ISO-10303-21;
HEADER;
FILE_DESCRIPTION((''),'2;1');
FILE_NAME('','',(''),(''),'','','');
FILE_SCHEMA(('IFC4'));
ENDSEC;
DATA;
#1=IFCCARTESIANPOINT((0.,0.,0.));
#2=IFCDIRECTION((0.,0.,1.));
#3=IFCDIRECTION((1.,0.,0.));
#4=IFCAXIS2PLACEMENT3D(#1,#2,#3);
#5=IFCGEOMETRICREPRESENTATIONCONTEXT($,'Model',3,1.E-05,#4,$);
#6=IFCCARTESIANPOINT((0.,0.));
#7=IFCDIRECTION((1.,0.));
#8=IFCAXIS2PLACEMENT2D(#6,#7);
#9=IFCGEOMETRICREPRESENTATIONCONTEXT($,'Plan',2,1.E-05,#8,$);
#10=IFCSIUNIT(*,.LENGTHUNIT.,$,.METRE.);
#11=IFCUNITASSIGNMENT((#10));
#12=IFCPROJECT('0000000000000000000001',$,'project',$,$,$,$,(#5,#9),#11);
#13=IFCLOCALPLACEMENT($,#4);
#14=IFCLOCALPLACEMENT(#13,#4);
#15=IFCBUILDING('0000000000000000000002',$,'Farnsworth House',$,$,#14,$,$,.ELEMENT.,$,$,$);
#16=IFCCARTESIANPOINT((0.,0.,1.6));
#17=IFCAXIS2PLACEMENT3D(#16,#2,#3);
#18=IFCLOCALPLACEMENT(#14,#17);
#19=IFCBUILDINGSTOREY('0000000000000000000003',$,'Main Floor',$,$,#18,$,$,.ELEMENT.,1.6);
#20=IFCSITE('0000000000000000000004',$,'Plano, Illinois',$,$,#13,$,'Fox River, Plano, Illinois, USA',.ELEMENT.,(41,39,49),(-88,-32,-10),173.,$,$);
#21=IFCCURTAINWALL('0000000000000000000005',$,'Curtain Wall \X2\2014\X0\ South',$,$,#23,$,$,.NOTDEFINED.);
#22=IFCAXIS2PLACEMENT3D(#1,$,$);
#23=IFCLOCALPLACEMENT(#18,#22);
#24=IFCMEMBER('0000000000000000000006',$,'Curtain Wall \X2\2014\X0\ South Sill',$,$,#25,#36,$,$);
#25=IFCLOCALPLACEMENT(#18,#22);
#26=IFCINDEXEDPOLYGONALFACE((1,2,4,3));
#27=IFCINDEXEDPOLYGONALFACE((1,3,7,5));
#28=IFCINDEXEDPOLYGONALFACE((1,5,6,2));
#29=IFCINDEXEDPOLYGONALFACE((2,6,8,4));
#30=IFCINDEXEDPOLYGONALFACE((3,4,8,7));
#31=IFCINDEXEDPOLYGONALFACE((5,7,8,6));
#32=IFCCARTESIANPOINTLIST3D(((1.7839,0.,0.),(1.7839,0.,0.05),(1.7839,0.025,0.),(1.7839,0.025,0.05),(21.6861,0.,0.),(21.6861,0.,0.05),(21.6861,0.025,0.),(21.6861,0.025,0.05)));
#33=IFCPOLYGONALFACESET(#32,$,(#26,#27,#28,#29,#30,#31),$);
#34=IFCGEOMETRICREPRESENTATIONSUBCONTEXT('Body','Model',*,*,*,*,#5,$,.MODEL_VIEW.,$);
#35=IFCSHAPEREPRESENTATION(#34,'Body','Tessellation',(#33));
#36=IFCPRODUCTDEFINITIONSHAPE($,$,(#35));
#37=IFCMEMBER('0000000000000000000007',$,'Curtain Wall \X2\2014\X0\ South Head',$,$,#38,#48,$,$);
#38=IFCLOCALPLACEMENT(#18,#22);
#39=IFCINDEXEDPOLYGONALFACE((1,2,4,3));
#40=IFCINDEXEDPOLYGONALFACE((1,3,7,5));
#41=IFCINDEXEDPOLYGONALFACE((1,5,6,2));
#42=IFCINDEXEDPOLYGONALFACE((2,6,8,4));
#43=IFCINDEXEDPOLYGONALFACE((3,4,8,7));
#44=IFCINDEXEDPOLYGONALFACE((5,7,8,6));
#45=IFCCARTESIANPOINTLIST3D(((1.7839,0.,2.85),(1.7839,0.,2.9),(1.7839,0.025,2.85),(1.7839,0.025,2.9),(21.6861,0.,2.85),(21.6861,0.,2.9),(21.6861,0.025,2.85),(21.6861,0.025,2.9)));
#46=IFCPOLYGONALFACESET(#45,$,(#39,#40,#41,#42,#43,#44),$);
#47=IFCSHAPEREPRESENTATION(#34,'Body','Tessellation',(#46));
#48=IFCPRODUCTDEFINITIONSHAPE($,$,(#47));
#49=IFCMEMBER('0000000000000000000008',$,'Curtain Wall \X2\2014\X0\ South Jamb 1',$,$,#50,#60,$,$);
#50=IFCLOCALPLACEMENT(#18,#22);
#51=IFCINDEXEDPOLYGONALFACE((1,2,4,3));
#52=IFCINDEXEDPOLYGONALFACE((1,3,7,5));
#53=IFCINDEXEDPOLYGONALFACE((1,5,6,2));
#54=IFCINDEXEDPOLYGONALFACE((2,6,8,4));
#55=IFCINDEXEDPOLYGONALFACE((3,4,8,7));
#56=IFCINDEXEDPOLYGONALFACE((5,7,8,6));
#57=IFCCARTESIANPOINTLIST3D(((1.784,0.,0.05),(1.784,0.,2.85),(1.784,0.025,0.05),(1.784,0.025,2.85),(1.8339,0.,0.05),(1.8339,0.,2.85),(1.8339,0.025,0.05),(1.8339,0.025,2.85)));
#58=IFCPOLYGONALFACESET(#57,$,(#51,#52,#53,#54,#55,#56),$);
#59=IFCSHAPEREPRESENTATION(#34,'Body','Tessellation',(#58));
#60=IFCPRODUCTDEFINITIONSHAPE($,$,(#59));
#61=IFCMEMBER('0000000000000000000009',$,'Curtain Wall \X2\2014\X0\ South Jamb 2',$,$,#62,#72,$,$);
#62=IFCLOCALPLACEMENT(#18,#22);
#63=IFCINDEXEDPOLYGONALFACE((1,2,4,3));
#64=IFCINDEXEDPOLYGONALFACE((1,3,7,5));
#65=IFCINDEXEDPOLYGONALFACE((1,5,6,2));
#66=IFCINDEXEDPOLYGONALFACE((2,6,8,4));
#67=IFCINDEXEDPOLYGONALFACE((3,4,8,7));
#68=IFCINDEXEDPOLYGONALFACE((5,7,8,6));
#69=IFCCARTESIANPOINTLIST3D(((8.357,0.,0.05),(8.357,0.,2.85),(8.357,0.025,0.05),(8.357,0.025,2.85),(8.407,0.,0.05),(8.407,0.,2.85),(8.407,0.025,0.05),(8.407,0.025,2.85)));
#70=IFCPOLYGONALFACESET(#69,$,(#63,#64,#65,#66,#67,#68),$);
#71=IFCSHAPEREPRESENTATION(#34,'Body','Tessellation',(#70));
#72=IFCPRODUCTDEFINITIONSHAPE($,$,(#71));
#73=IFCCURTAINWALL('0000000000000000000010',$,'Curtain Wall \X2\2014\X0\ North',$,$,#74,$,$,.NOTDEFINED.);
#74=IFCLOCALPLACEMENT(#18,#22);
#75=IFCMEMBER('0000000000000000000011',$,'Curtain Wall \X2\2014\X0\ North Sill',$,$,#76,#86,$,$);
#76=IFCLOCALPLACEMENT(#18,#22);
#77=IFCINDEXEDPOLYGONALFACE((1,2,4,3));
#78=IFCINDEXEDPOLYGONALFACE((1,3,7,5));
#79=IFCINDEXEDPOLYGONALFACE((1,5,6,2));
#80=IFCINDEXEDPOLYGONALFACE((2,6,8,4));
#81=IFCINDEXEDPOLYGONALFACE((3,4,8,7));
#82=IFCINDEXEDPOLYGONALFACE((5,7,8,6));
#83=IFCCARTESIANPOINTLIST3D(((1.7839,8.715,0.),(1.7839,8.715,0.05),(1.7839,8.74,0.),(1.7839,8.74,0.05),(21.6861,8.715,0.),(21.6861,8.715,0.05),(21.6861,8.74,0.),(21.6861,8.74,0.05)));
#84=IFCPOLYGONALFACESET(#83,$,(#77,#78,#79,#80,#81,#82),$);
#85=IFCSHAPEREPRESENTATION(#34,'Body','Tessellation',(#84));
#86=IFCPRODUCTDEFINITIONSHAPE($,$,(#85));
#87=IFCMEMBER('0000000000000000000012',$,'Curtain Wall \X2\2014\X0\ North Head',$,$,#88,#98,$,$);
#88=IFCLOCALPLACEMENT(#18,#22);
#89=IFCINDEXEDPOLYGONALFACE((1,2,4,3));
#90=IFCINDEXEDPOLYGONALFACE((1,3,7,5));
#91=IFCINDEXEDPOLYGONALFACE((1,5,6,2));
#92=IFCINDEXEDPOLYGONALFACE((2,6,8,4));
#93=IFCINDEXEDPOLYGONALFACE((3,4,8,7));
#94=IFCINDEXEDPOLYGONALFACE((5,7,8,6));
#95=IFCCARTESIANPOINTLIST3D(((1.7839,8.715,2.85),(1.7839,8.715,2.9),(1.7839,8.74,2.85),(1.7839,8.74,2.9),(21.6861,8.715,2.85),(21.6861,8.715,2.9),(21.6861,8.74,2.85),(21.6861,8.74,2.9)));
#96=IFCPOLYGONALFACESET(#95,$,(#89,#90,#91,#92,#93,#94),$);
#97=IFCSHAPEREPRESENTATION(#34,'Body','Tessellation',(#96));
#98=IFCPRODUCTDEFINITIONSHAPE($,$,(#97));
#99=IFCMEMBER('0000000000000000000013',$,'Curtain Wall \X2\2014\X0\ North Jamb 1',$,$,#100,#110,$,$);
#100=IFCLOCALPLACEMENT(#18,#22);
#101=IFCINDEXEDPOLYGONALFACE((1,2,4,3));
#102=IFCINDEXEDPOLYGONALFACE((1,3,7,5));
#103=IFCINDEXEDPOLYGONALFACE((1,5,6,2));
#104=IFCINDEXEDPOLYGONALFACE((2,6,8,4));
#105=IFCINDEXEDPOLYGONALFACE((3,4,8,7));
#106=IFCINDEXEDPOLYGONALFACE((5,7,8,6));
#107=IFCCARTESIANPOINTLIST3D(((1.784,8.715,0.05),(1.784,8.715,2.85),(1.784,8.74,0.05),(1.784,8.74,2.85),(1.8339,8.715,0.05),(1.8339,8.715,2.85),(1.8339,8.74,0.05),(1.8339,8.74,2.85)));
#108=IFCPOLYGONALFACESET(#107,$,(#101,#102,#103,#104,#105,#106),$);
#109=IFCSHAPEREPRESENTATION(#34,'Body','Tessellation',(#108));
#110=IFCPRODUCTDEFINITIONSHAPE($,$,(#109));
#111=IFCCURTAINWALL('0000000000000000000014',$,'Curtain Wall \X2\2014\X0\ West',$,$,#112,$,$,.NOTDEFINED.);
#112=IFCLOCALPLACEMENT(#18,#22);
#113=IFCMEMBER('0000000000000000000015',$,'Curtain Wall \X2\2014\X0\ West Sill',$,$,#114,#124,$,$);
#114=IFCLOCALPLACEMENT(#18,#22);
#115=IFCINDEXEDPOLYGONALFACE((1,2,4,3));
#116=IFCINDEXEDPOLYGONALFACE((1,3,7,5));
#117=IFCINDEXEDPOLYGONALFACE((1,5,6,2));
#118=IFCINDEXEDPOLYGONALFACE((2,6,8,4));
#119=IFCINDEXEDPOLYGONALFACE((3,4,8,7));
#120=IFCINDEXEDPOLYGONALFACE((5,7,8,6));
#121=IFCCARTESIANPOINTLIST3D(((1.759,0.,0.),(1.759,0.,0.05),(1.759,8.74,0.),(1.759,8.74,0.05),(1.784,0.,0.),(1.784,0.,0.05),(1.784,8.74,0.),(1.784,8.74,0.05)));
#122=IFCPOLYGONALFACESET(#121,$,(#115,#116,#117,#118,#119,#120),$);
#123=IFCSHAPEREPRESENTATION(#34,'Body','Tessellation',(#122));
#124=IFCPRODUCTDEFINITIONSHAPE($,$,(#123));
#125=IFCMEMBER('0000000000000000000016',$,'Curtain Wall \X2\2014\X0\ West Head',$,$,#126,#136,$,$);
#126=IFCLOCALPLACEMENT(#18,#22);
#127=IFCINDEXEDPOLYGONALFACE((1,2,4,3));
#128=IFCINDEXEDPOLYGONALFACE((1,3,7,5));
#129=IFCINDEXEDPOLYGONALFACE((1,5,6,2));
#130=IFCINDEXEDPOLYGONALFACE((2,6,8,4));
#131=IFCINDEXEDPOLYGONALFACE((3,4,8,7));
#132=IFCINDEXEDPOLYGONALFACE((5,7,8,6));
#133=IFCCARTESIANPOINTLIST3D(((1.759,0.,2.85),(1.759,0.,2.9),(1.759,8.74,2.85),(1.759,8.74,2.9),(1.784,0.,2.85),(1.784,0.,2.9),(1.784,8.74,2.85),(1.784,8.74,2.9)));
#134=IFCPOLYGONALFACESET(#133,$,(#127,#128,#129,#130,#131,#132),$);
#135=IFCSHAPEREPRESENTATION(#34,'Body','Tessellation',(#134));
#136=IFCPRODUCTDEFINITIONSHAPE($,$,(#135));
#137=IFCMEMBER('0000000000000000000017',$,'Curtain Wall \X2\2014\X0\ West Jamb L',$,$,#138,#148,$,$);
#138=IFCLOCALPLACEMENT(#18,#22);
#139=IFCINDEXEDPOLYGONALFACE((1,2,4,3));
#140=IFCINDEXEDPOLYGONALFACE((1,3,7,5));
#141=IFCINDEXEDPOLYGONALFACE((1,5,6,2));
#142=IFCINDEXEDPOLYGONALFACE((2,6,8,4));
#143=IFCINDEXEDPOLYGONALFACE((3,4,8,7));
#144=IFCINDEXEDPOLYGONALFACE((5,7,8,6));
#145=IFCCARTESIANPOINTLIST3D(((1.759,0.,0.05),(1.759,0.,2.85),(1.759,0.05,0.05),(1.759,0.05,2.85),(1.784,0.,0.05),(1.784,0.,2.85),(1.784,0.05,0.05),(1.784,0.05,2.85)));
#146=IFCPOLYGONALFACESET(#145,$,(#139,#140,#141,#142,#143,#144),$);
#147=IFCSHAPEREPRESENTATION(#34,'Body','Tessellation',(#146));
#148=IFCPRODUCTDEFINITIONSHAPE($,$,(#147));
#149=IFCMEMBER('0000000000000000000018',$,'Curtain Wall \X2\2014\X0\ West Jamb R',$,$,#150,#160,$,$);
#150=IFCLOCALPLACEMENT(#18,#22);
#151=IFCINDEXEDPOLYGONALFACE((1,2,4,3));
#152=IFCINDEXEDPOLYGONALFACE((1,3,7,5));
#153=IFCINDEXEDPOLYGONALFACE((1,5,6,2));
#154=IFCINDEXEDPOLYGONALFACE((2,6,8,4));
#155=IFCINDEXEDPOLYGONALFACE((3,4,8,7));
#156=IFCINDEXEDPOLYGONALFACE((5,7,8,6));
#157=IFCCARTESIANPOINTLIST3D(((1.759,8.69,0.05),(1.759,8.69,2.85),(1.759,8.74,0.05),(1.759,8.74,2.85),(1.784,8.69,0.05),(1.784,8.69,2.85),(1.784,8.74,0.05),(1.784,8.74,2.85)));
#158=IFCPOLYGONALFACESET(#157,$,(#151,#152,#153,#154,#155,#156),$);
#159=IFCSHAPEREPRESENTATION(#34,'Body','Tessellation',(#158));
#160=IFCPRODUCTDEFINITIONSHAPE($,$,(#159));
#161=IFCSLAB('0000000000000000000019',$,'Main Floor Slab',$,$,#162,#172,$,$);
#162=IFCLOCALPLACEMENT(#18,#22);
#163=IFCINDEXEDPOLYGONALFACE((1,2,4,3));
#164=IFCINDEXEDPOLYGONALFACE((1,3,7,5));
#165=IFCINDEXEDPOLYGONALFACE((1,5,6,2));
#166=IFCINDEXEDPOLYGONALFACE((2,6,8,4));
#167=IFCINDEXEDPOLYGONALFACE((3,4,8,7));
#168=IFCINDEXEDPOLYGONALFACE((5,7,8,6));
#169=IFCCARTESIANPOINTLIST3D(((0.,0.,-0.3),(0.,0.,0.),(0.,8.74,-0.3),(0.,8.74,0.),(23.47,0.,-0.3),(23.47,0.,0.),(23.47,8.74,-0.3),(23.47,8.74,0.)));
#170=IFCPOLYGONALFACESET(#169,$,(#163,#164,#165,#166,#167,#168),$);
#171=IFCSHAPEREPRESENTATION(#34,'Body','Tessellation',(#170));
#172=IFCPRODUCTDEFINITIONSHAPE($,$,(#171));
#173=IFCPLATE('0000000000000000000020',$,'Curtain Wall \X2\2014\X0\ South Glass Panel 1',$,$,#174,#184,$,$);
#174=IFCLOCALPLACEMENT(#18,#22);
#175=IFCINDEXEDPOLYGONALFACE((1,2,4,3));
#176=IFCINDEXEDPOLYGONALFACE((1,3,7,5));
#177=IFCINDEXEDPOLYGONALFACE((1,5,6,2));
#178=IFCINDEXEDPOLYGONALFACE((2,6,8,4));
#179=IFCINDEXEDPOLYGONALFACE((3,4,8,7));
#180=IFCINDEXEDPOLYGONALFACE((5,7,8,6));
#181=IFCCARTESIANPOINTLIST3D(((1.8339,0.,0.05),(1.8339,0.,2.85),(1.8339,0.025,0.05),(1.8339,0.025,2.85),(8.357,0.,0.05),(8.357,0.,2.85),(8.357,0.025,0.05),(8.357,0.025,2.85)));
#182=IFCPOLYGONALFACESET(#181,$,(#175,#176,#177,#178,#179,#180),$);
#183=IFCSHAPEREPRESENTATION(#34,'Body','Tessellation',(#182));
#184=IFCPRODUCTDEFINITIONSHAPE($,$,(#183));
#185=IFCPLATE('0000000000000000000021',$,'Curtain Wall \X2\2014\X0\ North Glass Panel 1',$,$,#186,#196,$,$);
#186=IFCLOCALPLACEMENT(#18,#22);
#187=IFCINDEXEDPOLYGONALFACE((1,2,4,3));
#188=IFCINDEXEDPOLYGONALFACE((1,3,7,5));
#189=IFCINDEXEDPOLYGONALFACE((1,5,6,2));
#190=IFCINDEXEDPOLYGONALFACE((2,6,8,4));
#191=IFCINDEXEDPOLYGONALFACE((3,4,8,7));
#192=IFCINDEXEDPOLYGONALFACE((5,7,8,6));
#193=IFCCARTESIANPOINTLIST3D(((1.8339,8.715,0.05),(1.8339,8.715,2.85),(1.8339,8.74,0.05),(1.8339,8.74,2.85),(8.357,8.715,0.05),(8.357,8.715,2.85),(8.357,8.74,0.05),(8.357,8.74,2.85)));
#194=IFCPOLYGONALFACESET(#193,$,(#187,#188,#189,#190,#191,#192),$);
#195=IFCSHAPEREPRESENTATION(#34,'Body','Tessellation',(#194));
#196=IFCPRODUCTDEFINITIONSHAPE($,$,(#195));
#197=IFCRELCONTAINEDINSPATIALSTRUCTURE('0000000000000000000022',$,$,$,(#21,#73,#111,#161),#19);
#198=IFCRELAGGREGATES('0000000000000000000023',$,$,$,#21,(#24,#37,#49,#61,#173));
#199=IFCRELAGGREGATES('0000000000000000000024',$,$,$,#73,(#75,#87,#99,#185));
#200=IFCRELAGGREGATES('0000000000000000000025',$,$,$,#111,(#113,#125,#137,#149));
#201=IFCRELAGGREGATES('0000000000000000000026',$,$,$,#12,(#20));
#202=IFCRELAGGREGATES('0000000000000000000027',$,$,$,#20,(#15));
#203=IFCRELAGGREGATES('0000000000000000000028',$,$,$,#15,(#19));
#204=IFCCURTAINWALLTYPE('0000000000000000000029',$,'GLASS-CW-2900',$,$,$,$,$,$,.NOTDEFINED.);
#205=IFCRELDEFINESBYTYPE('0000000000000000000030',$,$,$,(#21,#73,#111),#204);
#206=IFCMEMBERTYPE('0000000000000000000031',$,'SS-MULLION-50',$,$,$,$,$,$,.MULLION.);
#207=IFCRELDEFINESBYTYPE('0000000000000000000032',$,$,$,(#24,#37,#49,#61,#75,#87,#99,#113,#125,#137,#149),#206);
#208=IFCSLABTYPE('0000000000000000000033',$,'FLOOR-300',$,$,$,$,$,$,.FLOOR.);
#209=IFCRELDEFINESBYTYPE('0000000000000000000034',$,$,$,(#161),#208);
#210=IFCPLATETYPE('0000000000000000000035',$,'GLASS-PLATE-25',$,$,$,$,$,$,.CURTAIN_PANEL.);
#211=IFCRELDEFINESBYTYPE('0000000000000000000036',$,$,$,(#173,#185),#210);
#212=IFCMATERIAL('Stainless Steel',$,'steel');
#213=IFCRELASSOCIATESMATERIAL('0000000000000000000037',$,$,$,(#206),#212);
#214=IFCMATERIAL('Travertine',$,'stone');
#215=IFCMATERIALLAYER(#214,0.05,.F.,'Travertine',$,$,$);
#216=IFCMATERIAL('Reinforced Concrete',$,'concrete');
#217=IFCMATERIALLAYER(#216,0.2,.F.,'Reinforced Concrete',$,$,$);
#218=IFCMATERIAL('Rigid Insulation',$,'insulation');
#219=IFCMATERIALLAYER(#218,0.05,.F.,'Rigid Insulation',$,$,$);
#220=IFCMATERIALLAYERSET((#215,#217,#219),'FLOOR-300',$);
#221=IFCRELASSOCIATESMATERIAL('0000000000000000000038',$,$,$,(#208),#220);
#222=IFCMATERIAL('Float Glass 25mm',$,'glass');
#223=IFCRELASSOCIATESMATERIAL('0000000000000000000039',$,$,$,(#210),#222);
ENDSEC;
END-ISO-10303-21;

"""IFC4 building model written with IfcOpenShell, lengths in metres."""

from ifc_helpers import new_model, si_unit, frame, origin_with_axes, origin_2d_with_axis, place, context, subcontext, project, spatial, rectangle, extrude, material, layer, layer_set, layer_usage, type_object, element, aggregate, save


model = new_model("IFC4")

# Units and contexts
model_context = context("Model", 3, precision=1e-05, world=origin_with_axes())
plan_context = context("Plan", 2, precision=1e-05, world=origin_2d_with_axis())
body_context = subcontext(model_context, "Body", "Model", "MODEL_VIEW")
ifc_project = project(units=[si_unit("LENGTHUNIT", "METRE")], contexts=[model_context, plan_context])

# Site, building, storey
site_placement = place(None, origin_with_axes())
site = spatial("IfcSite", under=ifc_project, at=site_placement, Name="Plano, Illinois", LongName="Fox River, Plano, Illinois, USA", CompositionType="ELEMENT", RefLatitude=(41, 39, 49), RefLongitude=(-88, -32, -10), RefElevation=173.0)
building_placement = place(site_placement, origin_with_axes())
building = spatial("IfcBuilding", under=site, at=building_placement, Name="Farnsworth House", CompositionType="ELEMENT")
storey_placement = place(building_placement, frame((0.0, 0.0, 1.6), z_axis=(0.0, 0.0, 1.0), x_axis=(1.0, 0.0, 0.0)))
storey = spatial("IfcBuildingStorey", under=building, at=storey_placement, Name="Main Floor", CompositionType="ELEMENT", Elevation=1.6)

# Curtain walls, members
curtain_wall_type = type_object("IfcCurtainWallType", Name="GLASS-CW-2900", PredefinedType="NOTDEFINED")
curtain_wall_1_placement = place(storey_placement, frame((1.7839, 0.0, 0.0), z_axis=(0.0, 0.0, 1.0), x_axis=(1.0, 0.0, 0.0)))
curtain_wall_1 = element("IfcCurtainWall", 1, at=curtain_wall_1_placement, inside=storey, type_object=curtain_wall_type, Name="Curtain Wall — South", PredefinedType="NOTDEFINED")
ifc_material_1 = material(Name="Stainless Steel", Category="steel")
member_type = type_object("IfcMemberType", Name="SS-MULLION-50", PredefinedType="MULLION", material=ifc_material_1)
member_1_placement = place(curtain_wall_1_placement, origin_with_axes())
member_1 = element("IfcMember", 2, at=member_1_placement, type_object=member_type, Name="Curtain Wall — South Sill", context=body_context, shape_type="SweptSolid", body=[
    extrude(rectangle(XDim=19.9021, YDim=0.025, at=origin_2d_with_axis()), frame((9.9511, 0.0125, 0.0), z_axis=(0.0, 0.0, 1.0), x_axis=(1.0, 0.0, 0.0)), (0.0, 0.0, 1.0), 0.05),
])
member_2_placement = place(curtain_wall_1_placement, frame((0.0, 0.0, 2.85), z_axis=(0.0, 0.0, 1.0), x_axis=(1.0, 0.0, 0.0)))
member_2 = element("IfcMember", 3, at=member_2_placement, type_object=member_type, Name="Curtain Wall — South Head", context=body_context, shape_type="SweptSolid", body=[
    extrude(rectangle(XDim=19.9021, YDim=0.025, at=origin_2d_with_axis()), frame((9.9511, 0.0125, 0.0), z_axis=(0.0, 0.0, 1.0), x_axis=(1.0, 0.0, 0.0)), (0.0, 0.0, 1.0), 0.05),
])
member_3_placement = place(curtain_wall_1_placement, frame((0.0, 0.0, 0.05), z_axis=(0.0, 0.0, 1.0), x_axis=(1.0, 0.0, 0.0)))
member_3 = element("IfcMember", 4, at=member_3_placement, type_object=member_type, Name="Curtain Wall — South Jamb 1", context=body_context, shape_type="SweptSolid", body=[
    extrude(rectangle(XDim=0.05, YDim=0.025, at=origin_2d_with_axis()), frame((0.025, 0.0125, 0.0), z_axis=(0.0, 0.0, 1.0), x_axis=(1.0, 0.0, 0.0)), (0.0, 0.0, 1.0), 2.8),
])
member_4_placement = place(curtain_wall_1_placement, frame((6.573, 0.0, 0.05), z_axis=(0.0, 0.0, 1.0), x_axis=(1.0, 0.0, 0.0)))
member_4 = element("IfcMember", 5, at=member_4_placement, type_object=member_type, Name="Curtain Wall — South Jamb 2", context=body_context, shape_type="SweptSolid", body=[
    extrude(rectangle(XDim=0.05, YDim=0.025, at=origin_2d_with_axis()), frame((0.025, 0.0125, 0.0), z_axis=(0.0, 0.0, 1.0), x_axis=(1.0, 0.0, 0.0)), (0.0, 0.0, 1.0), 2.8),
])
curtain_wall_2_placement = place(storey_placement, frame((1.7839, 8.715, 0.0), z_axis=(0.0, 0.0, 1.0), x_axis=(1.0, 0.0, 0.0)))
curtain_wall_2 = element("IfcCurtainWall", 6, at=curtain_wall_2_placement, inside=storey, type_object=curtain_wall_type, Name="Curtain Wall — North", PredefinedType="NOTDEFINED")
member_5_placement = place(curtain_wall_2_placement, origin_with_axes())
member_5 = element("IfcMember", 7, at=member_5_placement, type_object=member_type, Name="Curtain Wall — North Sill", context=body_context, shape_type="SweptSolid", body=[
    extrude(rectangle(XDim=19.9021, YDim=0.025, at=origin_2d_with_axis()), frame((9.9511, 0.0125, 0.0), z_axis=(0.0, 0.0, 1.0), x_axis=(1.0, 0.0, 0.0)), (0.0, 0.0, 1.0), 0.05),
])
member_6_placement = place(curtain_wall_2_placement, frame((0.0, 0.0, 2.85), z_axis=(0.0, 0.0, 1.0), x_axis=(1.0, 0.0, 0.0)))
member_6 = element("IfcMember", 8, at=member_6_placement, type_object=member_type, Name="Curtain Wall — North Head", context=body_context, shape_type="SweptSolid", body=[
    extrude(rectangle(XDim=19.9021, YDim=0.025, at=origin_2d_with_axis()), frame((9.9511, 0.0125, 0.0), z_axis=(0.0, 0.0, 1.0), x_axis=(1.0, 0.0, 0.0)), (0.0, 0.0, 1.0), 0.05),
])
member_7_placement = place(curtain_wall_2_placement, frame((0.0, 0.0, 0.05), z_axis=(0.0, 0.0, 1.0), x_axis=(1.0, 0.0, 0.0)))
member_7 = element("IfcMember", 9, at=member_7_placement, type_object=member_type, Name="Curtain Wall — North Jamb 1", context=body_context, shape_type="SweptSolid", body=[
    extrude(rectangle(XDim=0.05, YDim=0.025, at=origin_2d_with_axis()), frame((0.025, 0.0125, 0.0), z_axis=(0.0, 0.0, 1.0), x_axis=(1.0, 0.0, 0.0)), (0.0, 0.0, 1.0), 2.8),
])
curtain_wall_3_placement = place(storey_placement, frame((1.7839, 0.0, 0.0), z_axis=(0.0, 0.0, 1.0), x_axis=(0.0, 1.0, 0.0)))
curtain_wall_3 = element("IfcCurtainWall", 10, at=curtain_wall_3_placement, inside=storey, type_object=curtain_wall_type, Name="Curtain Wall — West", PredefinedType="NOTDEFINED")
member_8_placement = place(curtain_wall_3_placement, origin_with_axes())
member_8 = element("IfcMember", 11, at=member_8_placement, type_object=member_type, Name="Curtain Wall — West Sill", context=body_context, shape_type="SweptSolid", body=[
    extrude(rectangle(XDim=8.74, YDim=0.025, at=origin_2d_with_axis()), frame((4.37, 0.0125, 0.0), z_axis=(0.0, 0.0, 1.0), x_axis=(1.0, 0.0, 0.0)), (0.0, 0.0, 1.0), 0.05),
])
member_9_placement = place(curtain_wall_3_placement, frame((0.0, 0.0, 2.85), z_axis=(0.0, 0.0, 1.0), x_axis=(1.0, 0.0, 0.0)))
member_9 = element("IfcMember", 12, at=member_9_placement, type_object=member_type, Name="Curtain Wall — West Head", context=body_context, shape_type="SweptSolid", body=[
    extrude(rectangle(XDim=8.74, YDim=0.025, at=origin_2d_with_axis()), frame((4.37, 0.0125, 0.0), z_axis=(0.0, 0.0, 1.0), x_axis=(1.0, 0.0, 0.0)), (0.0, 0.0, 1.0), 0.05),
])
member_10_placement = place(curtain_wall_3_placement, frame((0.0, 0.0, 0.05), z_axis=(0.0, 0.0, 1.0), x_axis=(1.0, 0.0, 0.0)))
member_10 = element("IfcMember", 13, at=member_10_placement, type_object=member_type, Name="Curtain Wall — West Jamb L", context=body_context, shape_type="SweptSolid", body=[
    extrude(rectangle(XDim=0.05, YDim=0.025, at=origin_2d_with_axis()), frame((0.025, 0.0125, 0.0), z_axis=(0.0, 0.0, 1.0), x_axis=(1.0, 0.0, 0.0)), (0.0, 0.0, 1.0), 2.8),
])
member_11_placement = place(curtain_wall_3_placement, frame((8.69, 0.0, 0.05), z_axis=(0.0, 0.0, 1.0), x_axis=(1.0, 0.0, 0.0)))
member_11 = element("IfcMember", 14, at=member_11_placement, type_object=member_type, Name="Curtain Wall — West Jamb R", context=body_context, shape_type="SweptSolid", body=[
    extrude(rectangle(XDim=0.05, YDim=0.025, at=origin_2d_with_axis()), frame((0.025, 0.0125, 0.0), z_axis=(0.0, 0.0, 1.0), x_axis=(1.0, 0.0, 0.0)), (0.0, 0.0, 1.0), 2.8),
])

# Slab
ifc_material_2 = material(Name="Travertine", Category="stone")
ifc_layer_1 = layer(ifc_material_2, 0.05, ventilated=False, Name="Travertine")
ifc_material_3 = material(Name="Reinforced Concrete", Category="concrete")
ifc_layer_2 = layer(ifc_material_3, 0.2, ventilated=False, Name="Reinforced Concrete")
ifc_material_4 = material(Name="Rigid Insulation", Category="insulation")
ifc_layer_3 = layer(ifc_material_4, 0.05, ventilated=False, Name="Rigid Insulation")
ifc_layer_set = layer_set([ifc_layer_1, ifc_layer_2, ifc_layer_3], Name="FLOOR-300")
ifc_layer_usage = layer_usage(ifc_layer_set, "AXIS3", "POSITIVE", -0.3)
slab_type = type_object("IfcSlabType", Name="FLOOR-300", PredefinedType="FLOOR", material=ifc_layer_usage)
slab_placement = place(storey_placement, frame((0.0, 0.0, -0.3), z_axis=(0.0, 0.0, 1.0), x_axis=(1.0, 0.0, 0.0)))
element("IfcSlab", 15, at=slab_placement, inside=storey, type_object=slab_type, Name="Main Floor Slab", context=body_context, shape_type="SweptSolid", body=[
    extrude(rectangle(XDim=23.47, YDim=8.74, at=origin_2d_with_axis()), frame((11.735, 4.37, 0.0), z_axis=(0.0, 0.0, 1.0), x_axis=(1.0, 0.0, 0.0)), (0.0, 0.0, 1.0), 0.3),
])

# Plates
ifc_material_5 = material(Name="Float Glass 25mm", Category="glass")
plate_type = type_object("IfcPlateType", Name="GLASS-PLATE-25", PredefinedType="CURTAIN_PANEL", material=ifc_material_5)
plate_1_placement = place(curtain_wall_1_placement, frame((0.05, 0.0, 0.05), z_axis=(0.0, 0.0, 1.0), x_axis=(1.0, 0.0, 0.0)))
plate_1 = element("IfcPlate", 16, at=plate_1_placement, type_object=plate_type, Name="Curtain Wall — South Glass Panel 1", context=body_context, shape_type="SweptSolid", body=[
    extrude(rectangle(XDim=6.523, YDim=0.025, at=origin_2d_with_axis()), frame((3.2615, 0.0125, 0.0), z_axis=(0.0, 0.0, 1.0), x_axis=(1.0, 0.0, 0.0)), (0.0, 0.0, 1.0), 2.8),
])
aggregate(curtain_wall_1, [member_1, member_2, member_3, member_4, plate_1])
plate_2_placement = place(curtain_wall_2_placement, frame((0.05, 0.0, 0.05), z_axis=(0.0, 0.0, 1.0), x_axis=(1.0, 0.0, 0.0)))
plate_2 = element("IfcPlate", 17, at=plate_2_placement, type_object=plate_type, Name="Curtain Wall — North Glass Panel 1", context=body_context, shape_type="SweptSolid", body=[
    extrude(rectangle(XDim=6.523, YDim=0.025, at=origin_2d_with_axis()), frame((3.2615, 0.0125, 0.0), z_axis=(0.0, 0.0, 1.0), x_axis=(1.0, 0.0, 0.0)), (0.0, 0.0, 1.0), 2.8),
])
aggregate(curtain_wall_2, [member_5, member_6, member_7, plate_2])
aggregate(curtain_wall_3, [member_8, member_9, member_10, member_11])

save(model, "model.ifc")
